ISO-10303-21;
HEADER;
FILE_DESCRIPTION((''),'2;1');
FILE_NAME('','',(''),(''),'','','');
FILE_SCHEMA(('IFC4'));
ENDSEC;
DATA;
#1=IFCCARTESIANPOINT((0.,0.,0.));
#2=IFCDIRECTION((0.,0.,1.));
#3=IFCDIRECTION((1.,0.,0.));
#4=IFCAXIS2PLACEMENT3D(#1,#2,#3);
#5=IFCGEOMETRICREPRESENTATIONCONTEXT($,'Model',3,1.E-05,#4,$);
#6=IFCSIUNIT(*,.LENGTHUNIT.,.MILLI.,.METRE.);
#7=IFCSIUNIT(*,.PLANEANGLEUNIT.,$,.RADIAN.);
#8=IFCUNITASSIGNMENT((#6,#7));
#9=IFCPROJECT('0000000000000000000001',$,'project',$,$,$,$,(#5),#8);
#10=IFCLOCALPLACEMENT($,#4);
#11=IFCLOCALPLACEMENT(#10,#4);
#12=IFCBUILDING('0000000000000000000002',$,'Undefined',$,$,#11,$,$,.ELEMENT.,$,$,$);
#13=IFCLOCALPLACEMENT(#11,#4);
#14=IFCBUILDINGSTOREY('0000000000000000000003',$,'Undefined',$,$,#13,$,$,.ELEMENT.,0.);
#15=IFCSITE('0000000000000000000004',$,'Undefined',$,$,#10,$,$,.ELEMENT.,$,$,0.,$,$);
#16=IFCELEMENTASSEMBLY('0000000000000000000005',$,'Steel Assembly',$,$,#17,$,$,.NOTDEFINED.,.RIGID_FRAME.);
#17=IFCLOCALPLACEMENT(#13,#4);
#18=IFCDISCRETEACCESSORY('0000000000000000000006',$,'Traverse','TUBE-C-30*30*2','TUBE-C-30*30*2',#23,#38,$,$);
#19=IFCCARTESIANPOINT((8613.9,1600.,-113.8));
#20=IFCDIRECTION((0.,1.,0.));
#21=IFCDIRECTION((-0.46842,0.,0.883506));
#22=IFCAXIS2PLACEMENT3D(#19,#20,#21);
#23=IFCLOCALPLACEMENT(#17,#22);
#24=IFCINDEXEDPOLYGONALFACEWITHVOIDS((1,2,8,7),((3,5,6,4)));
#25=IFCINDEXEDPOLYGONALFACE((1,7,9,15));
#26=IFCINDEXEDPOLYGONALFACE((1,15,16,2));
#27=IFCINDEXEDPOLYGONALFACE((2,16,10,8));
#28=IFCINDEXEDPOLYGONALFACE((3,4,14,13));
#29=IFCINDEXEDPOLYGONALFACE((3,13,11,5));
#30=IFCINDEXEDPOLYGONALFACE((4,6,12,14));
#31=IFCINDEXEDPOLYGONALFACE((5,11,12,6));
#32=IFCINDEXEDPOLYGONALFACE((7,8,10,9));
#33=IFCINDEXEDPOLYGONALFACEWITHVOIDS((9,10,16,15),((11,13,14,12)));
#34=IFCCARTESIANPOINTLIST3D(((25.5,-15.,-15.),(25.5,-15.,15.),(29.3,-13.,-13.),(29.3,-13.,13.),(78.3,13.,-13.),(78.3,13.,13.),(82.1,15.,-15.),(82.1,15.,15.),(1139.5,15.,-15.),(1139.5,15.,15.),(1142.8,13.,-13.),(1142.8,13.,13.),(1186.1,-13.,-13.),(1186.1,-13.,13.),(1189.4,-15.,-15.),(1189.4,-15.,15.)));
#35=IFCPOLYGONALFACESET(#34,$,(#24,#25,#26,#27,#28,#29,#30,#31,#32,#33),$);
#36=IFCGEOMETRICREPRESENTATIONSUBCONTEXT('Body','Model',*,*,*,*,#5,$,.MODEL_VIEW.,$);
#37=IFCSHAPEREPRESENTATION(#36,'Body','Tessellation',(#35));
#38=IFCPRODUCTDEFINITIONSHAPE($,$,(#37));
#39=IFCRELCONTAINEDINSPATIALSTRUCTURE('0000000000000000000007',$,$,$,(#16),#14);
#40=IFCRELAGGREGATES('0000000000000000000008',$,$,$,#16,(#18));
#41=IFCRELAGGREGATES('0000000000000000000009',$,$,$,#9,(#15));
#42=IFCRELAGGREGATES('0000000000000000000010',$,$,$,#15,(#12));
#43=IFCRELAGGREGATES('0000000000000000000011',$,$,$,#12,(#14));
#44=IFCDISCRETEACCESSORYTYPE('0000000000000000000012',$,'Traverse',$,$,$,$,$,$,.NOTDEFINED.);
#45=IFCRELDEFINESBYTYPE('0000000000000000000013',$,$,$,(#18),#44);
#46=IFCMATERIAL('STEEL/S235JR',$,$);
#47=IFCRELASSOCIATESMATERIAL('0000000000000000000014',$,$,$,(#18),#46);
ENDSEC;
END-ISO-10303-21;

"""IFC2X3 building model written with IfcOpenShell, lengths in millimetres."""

from ifc_helpers import new_model, si_unit, frame, origin_with_axes, origin_2d_with_axis, place, context, subcontext, project, spatial, hollow_rectangle, extrude, clip, halfspace, material, type_object, element, aggregate, save


model = new_model("IFC2X3")

# Units and contexts
model_context = context("Model", 3, precision=1e-05, world=origin_with_axes())
body_context = subcontext(model_context, "Body", "Model", "MODEL_VIEW")
ifc_project = project(units=[si_unit("LENGTHUNIT", "METRE", prefix="MILLI"), si_unit("PLANEANGLEUNIT", "RADIAN")], contexts=[model_context])

# Site, building, storey
site_placement = place(None, origin_with_axes())
site = spatial("IfcSite", under=ifc_project, at=site_placement, Name="Undefined", CompositionType="ELEMENT", RefElevation=0.0)
building_placement = place(site_placement, origin_with_axes())
building = spatial("IfcBuilding", under=site, at=building_placement, Name="Undefined", CompositionType="ELEMENT")
storey_placement = place(building_placement, origin_with_axes())
storey = spatial("IfcBuildingStorey", under=building, at=storey_placement, Name="Undefined", CompositionType="ELEMENT", Elevation=0.0)

# Shared definitions
ifc_material = material(Name="STEEL/S235JR")

# Element assembly
assembly_1_placement = place(storey_placement, origin_with_axes())
assembly_1 = element("IfcElementAssembly", 1, at=assembly_1_placement, inside=storey, Name="Steel Assembly", AssemblyPlace="NOTDEFINED", PredefinedType="RIGID_FRAME")

# Discrete accessory
discrete_accessory_type_1 = type_object("IfcDiscreteAccessoryType", Name="Traverse")
discrete_accessory_1_placement = place(assembly_1_placement, frame((8613.9, 1600.0, -113.8), z_axis=(0.0, 1.0, 0.0), x_axis=(-0.46842, 0.0, 0.883506)))
discrete_accessory_1 = element("IfcDiscreteAccessory", 2, at=discrete_accessory_1_placement, type_object=discrete_accessory_type_1, material=ifc_material, Name="Traverse", Description="TUBE-C-30*30*2", ObjectType="TUBE-C-30*30*2", context=body_context, shape_type="Clipping", body=[
    clip(clip(extrude(hollow_rectangle(XDim=30.0, YDim=30.0, WallThickness=2.0, at=origin_2d_with_axis()), frame((1218.2, 0.0, 0.0), z_axis=(-1.0, 0.0, 0.0), x_axis=(0.0, -1.0, 0.0)), (0.0, 0.0, 1.0), 1218.2), halfspace(frame((1139.5, 15.0, 0.0), z_axis=(-0.515548, -0.856861, -0.000003), x_axis=(0.000003, -0.000005, 1.0)), True)), halfspace(frame((82.1, 15.0, 0.0), z_axis=(-0.46842, 0.883506, 0.000005), x_axis=(0.000003, -0.000005, 1.0)), False)),
])
aggregate(assembly_1, [discrete_accessory_1])

save(model, "model.ifc")
